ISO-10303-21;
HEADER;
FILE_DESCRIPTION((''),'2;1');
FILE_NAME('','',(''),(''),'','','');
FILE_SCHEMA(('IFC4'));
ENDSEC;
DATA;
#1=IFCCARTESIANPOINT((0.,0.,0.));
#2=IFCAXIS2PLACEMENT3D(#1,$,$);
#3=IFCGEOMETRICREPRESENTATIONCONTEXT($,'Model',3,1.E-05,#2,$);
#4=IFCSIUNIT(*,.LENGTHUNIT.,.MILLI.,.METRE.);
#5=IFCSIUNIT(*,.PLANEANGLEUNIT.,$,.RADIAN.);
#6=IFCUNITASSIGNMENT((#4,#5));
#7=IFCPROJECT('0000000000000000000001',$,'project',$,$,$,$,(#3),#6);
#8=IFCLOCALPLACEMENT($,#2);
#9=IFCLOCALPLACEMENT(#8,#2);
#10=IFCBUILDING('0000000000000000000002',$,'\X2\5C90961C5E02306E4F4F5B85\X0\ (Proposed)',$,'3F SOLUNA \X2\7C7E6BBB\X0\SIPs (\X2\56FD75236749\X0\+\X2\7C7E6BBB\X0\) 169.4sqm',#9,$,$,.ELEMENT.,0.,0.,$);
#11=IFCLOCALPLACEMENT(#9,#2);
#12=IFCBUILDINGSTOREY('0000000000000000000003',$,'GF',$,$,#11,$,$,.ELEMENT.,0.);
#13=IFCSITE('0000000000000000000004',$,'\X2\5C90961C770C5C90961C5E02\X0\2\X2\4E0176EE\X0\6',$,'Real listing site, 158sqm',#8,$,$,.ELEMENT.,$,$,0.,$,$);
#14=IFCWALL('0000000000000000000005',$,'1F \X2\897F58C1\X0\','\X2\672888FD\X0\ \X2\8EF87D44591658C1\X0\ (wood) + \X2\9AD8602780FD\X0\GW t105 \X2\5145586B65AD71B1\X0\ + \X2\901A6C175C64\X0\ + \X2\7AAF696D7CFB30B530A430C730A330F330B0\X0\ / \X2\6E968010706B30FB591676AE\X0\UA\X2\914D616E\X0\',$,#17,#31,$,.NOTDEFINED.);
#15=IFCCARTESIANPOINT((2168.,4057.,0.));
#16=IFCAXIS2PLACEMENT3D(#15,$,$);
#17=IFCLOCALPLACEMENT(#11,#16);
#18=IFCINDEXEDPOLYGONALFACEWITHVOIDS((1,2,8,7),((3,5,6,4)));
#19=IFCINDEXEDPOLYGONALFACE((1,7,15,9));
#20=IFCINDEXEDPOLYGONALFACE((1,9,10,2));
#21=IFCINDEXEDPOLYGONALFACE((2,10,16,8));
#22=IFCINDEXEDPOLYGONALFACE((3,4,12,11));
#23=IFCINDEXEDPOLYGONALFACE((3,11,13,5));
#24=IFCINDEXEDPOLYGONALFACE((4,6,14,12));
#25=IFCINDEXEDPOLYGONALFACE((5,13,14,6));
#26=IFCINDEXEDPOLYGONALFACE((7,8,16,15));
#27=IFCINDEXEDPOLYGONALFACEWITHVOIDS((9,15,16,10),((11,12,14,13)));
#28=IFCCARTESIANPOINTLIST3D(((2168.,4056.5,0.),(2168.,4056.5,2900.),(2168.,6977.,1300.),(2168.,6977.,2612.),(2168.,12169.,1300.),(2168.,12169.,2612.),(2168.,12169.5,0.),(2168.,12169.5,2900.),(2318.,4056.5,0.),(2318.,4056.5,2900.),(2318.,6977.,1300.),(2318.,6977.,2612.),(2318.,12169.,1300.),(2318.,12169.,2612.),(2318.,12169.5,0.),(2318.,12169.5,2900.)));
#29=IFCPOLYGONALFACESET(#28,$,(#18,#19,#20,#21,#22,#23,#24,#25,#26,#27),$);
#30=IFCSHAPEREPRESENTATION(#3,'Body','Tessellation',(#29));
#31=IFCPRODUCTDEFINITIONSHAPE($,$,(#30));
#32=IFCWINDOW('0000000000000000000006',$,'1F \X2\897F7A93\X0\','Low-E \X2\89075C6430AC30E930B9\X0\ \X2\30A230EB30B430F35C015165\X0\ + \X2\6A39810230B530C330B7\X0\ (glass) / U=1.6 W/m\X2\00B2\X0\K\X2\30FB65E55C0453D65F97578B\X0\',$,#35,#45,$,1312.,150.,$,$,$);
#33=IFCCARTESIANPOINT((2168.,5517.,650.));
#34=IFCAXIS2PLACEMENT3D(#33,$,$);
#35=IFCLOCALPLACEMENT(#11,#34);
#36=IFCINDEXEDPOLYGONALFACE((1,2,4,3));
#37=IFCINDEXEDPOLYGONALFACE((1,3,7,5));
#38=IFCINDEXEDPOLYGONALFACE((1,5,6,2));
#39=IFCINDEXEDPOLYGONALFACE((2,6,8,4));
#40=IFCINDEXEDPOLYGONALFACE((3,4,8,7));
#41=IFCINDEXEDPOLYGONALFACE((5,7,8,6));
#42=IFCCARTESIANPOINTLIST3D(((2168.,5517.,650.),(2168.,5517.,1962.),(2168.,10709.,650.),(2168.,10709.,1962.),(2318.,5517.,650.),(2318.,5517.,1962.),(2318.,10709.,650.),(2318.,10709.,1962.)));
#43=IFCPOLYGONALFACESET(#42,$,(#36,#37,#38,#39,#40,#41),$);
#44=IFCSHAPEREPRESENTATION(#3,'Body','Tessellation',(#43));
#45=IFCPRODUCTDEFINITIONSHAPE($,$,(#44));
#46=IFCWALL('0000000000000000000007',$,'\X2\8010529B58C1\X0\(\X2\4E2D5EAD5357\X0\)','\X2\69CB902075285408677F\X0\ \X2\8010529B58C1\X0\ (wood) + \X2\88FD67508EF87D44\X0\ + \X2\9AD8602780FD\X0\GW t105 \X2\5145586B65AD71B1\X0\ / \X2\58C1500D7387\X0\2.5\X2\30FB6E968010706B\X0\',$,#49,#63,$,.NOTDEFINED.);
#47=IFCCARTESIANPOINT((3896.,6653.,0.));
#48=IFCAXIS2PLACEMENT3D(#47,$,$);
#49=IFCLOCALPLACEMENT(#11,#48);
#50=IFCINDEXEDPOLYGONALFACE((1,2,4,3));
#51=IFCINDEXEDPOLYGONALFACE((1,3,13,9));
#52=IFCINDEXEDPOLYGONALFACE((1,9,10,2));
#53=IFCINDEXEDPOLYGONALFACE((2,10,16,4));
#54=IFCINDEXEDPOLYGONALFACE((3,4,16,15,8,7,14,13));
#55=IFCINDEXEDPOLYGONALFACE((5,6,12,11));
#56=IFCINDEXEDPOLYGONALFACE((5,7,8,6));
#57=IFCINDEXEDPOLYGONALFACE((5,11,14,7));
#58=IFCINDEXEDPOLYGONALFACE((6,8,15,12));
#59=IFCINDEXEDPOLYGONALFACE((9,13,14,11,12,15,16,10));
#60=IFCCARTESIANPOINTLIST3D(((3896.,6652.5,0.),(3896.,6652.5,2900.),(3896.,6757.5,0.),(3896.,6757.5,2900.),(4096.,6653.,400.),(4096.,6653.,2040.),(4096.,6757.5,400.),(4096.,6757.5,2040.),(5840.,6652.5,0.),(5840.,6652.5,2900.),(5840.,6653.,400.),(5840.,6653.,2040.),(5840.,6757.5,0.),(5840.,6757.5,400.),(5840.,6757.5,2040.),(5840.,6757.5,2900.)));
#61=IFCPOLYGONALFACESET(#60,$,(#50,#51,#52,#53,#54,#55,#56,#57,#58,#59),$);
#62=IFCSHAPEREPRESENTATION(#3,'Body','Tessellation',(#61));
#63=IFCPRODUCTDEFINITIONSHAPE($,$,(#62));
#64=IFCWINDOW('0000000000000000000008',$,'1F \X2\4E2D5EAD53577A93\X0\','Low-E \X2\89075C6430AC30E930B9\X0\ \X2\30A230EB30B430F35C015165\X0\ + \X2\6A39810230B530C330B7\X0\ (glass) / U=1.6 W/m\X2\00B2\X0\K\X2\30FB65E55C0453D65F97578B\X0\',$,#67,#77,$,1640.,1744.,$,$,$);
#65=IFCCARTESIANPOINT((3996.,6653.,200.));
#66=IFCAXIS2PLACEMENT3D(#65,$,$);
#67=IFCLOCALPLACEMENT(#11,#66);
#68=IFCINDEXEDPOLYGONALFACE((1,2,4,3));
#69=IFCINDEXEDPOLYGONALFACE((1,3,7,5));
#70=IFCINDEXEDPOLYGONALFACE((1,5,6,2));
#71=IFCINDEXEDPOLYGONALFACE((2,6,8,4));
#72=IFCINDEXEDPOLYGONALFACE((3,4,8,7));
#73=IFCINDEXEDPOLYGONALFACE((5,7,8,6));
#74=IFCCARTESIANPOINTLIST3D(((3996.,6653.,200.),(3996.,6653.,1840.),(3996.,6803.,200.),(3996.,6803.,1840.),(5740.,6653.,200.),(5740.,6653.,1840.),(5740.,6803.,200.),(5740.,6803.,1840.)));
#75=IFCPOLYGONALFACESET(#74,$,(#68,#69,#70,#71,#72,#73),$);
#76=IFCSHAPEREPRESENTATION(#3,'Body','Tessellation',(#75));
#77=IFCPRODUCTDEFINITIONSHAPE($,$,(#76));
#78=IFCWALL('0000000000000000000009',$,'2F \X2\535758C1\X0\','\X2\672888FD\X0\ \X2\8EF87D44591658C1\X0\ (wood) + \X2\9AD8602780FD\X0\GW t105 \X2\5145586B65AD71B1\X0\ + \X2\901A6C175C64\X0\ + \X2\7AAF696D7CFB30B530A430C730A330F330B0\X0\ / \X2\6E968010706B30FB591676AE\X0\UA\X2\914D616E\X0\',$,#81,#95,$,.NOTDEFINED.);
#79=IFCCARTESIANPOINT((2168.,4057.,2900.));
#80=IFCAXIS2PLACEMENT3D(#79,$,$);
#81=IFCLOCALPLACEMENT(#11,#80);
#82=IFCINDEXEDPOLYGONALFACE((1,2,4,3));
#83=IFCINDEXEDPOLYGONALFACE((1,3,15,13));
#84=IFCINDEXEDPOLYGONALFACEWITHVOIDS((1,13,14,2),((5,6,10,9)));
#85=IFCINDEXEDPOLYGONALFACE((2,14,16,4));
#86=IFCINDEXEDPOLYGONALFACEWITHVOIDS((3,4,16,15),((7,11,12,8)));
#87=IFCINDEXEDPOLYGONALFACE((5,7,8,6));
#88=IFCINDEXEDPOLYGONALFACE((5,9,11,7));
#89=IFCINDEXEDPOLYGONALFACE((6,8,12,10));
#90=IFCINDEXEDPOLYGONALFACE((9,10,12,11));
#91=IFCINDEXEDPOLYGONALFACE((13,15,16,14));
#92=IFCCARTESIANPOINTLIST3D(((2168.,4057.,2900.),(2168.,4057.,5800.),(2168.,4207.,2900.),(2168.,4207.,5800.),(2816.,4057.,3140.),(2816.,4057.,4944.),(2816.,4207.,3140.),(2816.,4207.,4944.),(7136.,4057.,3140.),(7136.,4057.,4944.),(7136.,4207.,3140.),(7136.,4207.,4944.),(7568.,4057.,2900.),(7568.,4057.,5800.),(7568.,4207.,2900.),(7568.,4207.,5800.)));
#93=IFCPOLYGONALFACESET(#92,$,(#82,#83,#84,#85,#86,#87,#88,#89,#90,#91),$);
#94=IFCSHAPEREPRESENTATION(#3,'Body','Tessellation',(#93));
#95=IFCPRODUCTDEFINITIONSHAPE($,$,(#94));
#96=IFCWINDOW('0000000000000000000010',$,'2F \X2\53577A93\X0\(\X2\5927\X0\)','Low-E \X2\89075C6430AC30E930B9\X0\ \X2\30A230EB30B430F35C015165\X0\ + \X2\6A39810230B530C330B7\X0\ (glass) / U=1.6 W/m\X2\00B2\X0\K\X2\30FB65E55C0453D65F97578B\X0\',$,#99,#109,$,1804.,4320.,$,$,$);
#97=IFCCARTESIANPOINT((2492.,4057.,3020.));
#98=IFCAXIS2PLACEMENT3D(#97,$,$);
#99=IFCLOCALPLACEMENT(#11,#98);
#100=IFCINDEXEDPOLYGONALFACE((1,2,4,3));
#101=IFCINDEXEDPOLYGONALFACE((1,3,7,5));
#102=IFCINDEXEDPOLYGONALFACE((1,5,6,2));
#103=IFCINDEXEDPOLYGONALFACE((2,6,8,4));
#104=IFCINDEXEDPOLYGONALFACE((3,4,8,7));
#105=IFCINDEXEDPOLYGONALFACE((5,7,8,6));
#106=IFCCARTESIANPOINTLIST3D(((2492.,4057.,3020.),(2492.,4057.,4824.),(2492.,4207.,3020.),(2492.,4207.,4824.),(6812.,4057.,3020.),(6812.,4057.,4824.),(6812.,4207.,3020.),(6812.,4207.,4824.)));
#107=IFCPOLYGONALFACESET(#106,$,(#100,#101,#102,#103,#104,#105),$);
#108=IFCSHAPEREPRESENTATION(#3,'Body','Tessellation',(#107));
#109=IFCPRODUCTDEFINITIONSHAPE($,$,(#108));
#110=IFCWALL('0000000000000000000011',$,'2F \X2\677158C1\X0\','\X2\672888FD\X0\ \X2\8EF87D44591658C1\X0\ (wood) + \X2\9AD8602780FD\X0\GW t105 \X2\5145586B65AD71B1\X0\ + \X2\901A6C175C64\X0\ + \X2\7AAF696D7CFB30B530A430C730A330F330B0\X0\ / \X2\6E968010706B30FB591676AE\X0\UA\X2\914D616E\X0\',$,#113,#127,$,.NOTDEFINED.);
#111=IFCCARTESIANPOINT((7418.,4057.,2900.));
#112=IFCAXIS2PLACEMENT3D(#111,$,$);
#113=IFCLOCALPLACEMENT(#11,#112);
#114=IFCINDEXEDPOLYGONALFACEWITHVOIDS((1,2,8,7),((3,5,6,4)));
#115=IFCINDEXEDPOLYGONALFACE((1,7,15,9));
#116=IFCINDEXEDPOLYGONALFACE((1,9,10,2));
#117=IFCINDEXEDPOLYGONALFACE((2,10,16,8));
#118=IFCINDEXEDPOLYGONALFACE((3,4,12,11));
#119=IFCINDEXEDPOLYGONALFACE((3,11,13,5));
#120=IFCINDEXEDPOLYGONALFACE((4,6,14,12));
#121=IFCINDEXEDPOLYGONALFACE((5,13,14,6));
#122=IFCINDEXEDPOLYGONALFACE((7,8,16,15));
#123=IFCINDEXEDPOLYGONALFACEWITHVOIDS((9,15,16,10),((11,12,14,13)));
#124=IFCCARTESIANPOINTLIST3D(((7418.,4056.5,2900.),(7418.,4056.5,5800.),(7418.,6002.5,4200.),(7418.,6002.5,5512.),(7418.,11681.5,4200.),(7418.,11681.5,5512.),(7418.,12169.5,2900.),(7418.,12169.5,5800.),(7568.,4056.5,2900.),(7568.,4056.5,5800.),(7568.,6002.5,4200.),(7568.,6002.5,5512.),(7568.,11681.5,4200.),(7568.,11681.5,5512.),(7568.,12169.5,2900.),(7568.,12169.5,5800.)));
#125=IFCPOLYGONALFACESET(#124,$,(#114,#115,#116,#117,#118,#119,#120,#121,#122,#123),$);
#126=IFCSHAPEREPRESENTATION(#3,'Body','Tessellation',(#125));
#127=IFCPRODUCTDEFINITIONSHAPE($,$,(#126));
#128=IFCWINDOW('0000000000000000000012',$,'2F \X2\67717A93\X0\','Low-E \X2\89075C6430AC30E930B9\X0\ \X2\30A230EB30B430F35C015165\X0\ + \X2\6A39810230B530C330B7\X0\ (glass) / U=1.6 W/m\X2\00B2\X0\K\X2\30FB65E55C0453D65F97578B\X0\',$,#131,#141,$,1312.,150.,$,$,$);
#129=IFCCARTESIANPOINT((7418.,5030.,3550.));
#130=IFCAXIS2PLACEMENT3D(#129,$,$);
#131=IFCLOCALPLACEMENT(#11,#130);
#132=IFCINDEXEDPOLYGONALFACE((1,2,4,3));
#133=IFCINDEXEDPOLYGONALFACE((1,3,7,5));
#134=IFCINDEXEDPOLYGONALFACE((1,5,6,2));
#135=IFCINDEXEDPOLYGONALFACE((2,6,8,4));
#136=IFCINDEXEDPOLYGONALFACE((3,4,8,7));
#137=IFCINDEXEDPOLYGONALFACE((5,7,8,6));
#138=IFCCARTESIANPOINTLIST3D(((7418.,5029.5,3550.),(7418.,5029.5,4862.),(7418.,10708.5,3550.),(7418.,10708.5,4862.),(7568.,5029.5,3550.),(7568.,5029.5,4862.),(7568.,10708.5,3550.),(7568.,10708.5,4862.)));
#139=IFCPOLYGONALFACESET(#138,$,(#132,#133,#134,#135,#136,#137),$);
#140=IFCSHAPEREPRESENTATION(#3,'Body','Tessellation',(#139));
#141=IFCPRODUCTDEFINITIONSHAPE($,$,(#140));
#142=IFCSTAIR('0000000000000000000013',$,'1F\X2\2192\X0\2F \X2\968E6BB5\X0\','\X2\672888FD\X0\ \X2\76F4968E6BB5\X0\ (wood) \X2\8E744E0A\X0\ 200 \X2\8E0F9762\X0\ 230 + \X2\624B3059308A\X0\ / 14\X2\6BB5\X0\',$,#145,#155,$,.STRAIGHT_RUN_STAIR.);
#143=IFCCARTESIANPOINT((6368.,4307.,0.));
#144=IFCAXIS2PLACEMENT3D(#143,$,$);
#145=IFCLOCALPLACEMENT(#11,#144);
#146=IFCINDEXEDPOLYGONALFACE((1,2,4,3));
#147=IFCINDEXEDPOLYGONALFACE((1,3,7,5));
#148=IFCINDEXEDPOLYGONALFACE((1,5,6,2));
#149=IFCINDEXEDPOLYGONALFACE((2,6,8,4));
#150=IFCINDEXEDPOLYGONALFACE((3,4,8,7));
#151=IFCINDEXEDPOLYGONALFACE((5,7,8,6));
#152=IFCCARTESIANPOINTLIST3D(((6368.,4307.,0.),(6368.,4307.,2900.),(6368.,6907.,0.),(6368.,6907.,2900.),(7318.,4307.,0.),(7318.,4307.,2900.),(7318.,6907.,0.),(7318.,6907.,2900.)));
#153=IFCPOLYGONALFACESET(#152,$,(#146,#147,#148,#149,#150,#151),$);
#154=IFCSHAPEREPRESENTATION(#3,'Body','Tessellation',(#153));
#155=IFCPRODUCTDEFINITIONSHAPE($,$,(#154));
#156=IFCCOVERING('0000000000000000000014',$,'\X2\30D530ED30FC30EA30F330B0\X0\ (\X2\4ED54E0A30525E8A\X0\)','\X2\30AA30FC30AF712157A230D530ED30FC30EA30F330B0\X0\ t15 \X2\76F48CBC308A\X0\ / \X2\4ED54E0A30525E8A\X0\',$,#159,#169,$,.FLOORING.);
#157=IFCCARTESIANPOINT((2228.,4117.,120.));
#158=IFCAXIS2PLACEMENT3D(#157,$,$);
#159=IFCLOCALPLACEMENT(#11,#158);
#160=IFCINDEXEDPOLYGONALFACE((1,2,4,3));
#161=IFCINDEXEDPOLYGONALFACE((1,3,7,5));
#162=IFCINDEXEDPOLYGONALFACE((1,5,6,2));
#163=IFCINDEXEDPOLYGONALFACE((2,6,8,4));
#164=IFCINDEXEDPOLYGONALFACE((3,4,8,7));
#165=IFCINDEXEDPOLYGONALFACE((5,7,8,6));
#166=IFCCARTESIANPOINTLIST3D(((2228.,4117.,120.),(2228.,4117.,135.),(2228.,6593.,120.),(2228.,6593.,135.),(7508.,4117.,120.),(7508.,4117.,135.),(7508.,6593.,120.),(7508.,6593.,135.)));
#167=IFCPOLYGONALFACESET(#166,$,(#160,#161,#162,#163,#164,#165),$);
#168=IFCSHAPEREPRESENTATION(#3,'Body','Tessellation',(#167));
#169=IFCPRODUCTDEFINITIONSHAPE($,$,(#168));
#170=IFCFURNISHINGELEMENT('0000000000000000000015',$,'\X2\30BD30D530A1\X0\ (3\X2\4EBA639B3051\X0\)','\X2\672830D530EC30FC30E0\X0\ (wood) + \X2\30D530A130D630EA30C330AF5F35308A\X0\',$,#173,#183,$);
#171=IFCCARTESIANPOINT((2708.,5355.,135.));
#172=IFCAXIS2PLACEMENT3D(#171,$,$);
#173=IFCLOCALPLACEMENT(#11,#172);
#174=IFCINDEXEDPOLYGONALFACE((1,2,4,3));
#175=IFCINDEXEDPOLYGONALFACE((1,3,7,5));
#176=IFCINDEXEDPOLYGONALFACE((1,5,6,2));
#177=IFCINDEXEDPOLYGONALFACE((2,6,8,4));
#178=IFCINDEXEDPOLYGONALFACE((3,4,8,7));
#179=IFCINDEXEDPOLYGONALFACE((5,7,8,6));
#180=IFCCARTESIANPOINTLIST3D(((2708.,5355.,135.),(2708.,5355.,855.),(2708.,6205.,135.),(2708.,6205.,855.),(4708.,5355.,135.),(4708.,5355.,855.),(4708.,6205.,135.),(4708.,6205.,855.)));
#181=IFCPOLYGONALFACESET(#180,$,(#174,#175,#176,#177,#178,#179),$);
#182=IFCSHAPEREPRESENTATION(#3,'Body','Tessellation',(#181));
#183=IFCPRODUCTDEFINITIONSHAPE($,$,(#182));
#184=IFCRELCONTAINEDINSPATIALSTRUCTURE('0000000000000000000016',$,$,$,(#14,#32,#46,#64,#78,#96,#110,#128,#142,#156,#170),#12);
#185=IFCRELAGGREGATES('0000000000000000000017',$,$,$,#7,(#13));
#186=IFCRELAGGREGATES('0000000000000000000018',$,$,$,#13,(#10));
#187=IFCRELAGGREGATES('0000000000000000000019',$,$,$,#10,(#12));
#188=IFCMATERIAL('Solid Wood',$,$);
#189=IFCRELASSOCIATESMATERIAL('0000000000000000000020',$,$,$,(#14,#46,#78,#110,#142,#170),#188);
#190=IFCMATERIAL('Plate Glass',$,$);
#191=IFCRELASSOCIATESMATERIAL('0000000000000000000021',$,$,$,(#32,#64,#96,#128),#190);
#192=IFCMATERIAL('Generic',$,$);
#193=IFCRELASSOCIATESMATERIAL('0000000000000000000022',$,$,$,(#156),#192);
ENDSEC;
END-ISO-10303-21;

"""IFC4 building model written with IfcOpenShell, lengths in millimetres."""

from ifc_helpers import new_model, si_unit, frame, frame_2d, origin, place, context, project, spatial, rectangle, extrude, material, element, fill, save


model = new_model("IFC4")

# Units and contexts
model_context = context("Model", 3, precision=1e-05, world=origin())
ifc_project = project(units=[si_unit("LENGTHUNIT", "METRE", prefix="MILLI"), si_unit("PLANEANGLEUNIT", "RADIAN")], contexts=[model_context])

# Site, building, storey
site_placement = place(None, origin())
site = spatial("IfcSite", under=ifc_project, at=site_placement, Name="岐阜県岐阜市2丁目6", ObjectType="Real listing site, 158sqm", CompositionType="ELEMENT", RefElevation=0.0)
building_placement = place(site_placement, origin())
building = spatial("IfcBuilding", under=site, at=building_placement, Name="岐阜市の住宅 (Proposed)", ObjectType="3F SOLUNA 籾殻SIPs (国産杉+籾殻) 169.4sqm", CompositionType="ELEMENT", ElevationOfRefHeight=0.0, ElevationOfTerrain=0.0)
storey_placement = place(building_placement, origin())
storey = spatial("IfcBuildingStorey", under=building, at=storey_placement, Name="GF", CompositionType="ELEMENT", Elevation=0.0)

# Shared definitions
ifc_material_1 = material(Name="Solid Wood")
ifc_material_2 = material(Name="Generic")

# Shared definitions
ifc_material_3 = material(Name="Plate Glass")

# Walls, openings, windows
wall_1_placement = place(storey_placement, frame((2168.0, 4057.0, 0.0)))
wall_1 = element("IfcWall", 1, at=wall_1_placement, inside=storey, material=ifc_material_1, Name="1F 西壁", Description="木製 軸組外壁 (wood) + 高性能GW t105 充填断熱 + 通気層 + 窯業系サイディング / 準耐火・外皮UA配慮", PredefinedType="NOTDEFINED", context=model_context, shape_type="SweptSolid", body=[
    extrude(rectangle(XDim=150.0, YDim=8113.0, at=frame_2d((75.0, 4056.0))), frame((2168.0, 4057.0, 0.0)), (0.0, 0.0, 1.0), 2900.0),
])
opening_1_placement = place(storey_placement, frame((2168.0, 5517.0, 650.0)))
opening_1 = element("IfcOpeningElement", 2, at=opening_1_placement, cuts=wall_1, PredefinedType="NOTDEFINED", context=model_context, shape_type="SweptSolid", body=[
    extrude(rectangle(XDim=150.0, YDim=5192.0, at=frame_2d((75.0, 2596.0))), frame((2168.0, 5517.0, 650.0)), (0.0, 0.0, 1.0), 1312.0),
])
window_1_placement = place(storey_placement, frame((2168.0, 5517.0, 650.0)))
window_1 = element("IfcWindow", 3, at=window_1_placement, inside=storey, material=ifc_material_3, Name="1F 西窓", Description="Low-E 複層ガラス アルゴン封入 + 樹脂サッシ (glass) / U=1.6 W/m²K・日射取得型", OverallHeight=1312.0, OverallWidth=150.0, context=model_context, shape_type="SweptSolid", body=[
    extrude(rectangle(XDim=150.0, YDim=5192.0, at=frame_2d((75.0, 2596.0))), frame((2168.0, 5517.0, 650.0)), (0.0, 0.0, 1.0), 1312.0),
])
fill(opening_1, window_1)
wall_2_placement = place(storey_placement, frame((3896.0, 6653.0, 0.0)))
wall_2 = element("IfcWall", 4, at=wall_2_placement, inside=storey, material=ifc_material_1, Name="耐力壁(中庭南)", Description="構造用合板 耐力壁 (wood) + 製材軸組 + 高性能GW t105 充填断熱 / 壁倍率2.5・準耐火", PredefinedType="NOTDEFINED", context=model_context, shape_type="SweptSolid", body=[
    extrude(rectangle(XDim=1944.0, YDim=105.0, at=frame_2d((972.0, 52.0))), frame((3896.0, 6653.0, 0.0)), (0.0, 0.0, 1.0), 2900.0),
])
opening_2_placement = place(storey_placement, frame((3996.0, 6653.0, 200.0)))
opening_2 = element("IfcOpeningElement", 5, at=opening_2_placement, cuts=wall_2, PredefinedType="NOTDEFINED", context=model_context, shape_type="SweptSolid", body=[
    extrude(rectangle(XDim=1744.0, YDim=150.0, at=frame_2d((872.0, 75.0))), frame((3996.0, 6653.0, 200.0)), (0.0, 0.0, 1.0), 1640.0),
])
window_2_placement = place(storey_placement, frame((3996.0, 6653.0, 200.0)))
window_2 = element("IfcWindow", 6, at=window_2_placement, inside=storey, material=ifc_material_3, Name="1F 中庭南窓", Description="Low-E 複層ガラス アルゴン封入 + 樹脂サッシ (glass) / U=1.6 W/m²K・日射取得型", OverallHeight=1640.0, OverallWidth=1744.0, context=model_context, shape_type="SweptSolid", body=[
    extrude(rectangle(XDim=1744.0, YDim=150.0, at=frame_2d((872.0, 75.0))), frame((3996.0, 6653.0, 200.0)), (0.0, 0.0, 1.0), 1640.0),
])
fill(opening_2, window_2)

# Walls, openings, windows
wall_3_placement = place(storey_placement, frame((2168.0, 4057.0, 2900.0)))
wall_3 = element("IfcWall", 7, at=wall_3_placement, inside=storey, material=ifc_material_1, Name="2F 南壁", Description="木製 軸組外壁 (wood) + 高性能GW t105 充填断熱 + 通気層 + 窯業系サイディング / 準耐火・外皮UA配慮", PredefinedType="NOTDEFINED", context=model_context, shape_type="SweptSolid", body=[
    extrude(rectangle(XDim=5400.0, YDim=150.0, at=frame_2d((2700.0, 75.0))), frame((2168.0, 4057.0, 2900.0)), (0.0, 0.0, 1.0), 2900.0),
])
opening_3_placement = place(storey_placement, frame((2492.0, 4057.0, 3020.0)))
opening_3 = element("IfcOpeningElement", 8, at=opening_3_placement, cuts=wall_3, PredefinedType="NOTDEFINED", context=model_context, shape_type="SweptSolid", body=[
    extrude(rectangle(XDim=4320.0, YDim=150.0, at=frame_2d((2160.0, 75.0))), frame((2492.0, 4057.0, 3020.0)), (0.0, 0.0, 1.0), 1804.0),
])
window_3_placement = place(storey_placement, frame((2492.0, 4057.0, 3020.0)))
window_3 = element("IfcWindow", 9, at=window_3_placement, inside=storey, material=ifc_material_3, Name="2F 南窓(大)", Description="Low-E 複層ガラス アルゴン封入 + 樹脂サッシ (glass) / U=1.6 W/m²K・日射取得型", OverallHeight=1804.0, OverallWidth=4320.0, context=model_context, shape_type="SweptSolid", body=[
    extrude(rectangle(XDim=4320.0, YDim=150.0, at=frame_2d((2160.0, 75.0))), frame((2492.0, 4057.0, 3020.0)), (0.0, 0.0, 1.0), 1804.0),
])
fill(opening_3, window_3)
wall_4_placement = place(storey_placement, frame((7418.0, 4057.0, 2900.0)))
wall_4 = element("IfcWall", 10, at=wall_4_placement, inside=storey, material=ifc_material_1, Name="2F 東壁", Description="木製 軸組外壁 (wood) + 高性能GW t105 充填断熱 + 通気層 + 窯業系サイディング / 準耐火・外皮UA配慮", PredefinedType="NOTDEFINED", context=model_context, shape_type="SweptSolid", body=[
    extrude(rectangle(XDim=150.0, YDim=8113.0, at=frame_2d((75.0, 4056.0))), frame((7418.0, 4057.0, 2900.0)), (0.0, 0.0, 1.0), 2900.0),
])
opening_4_placement = place(storey_placement, frame((7418.0, 5030.0, 3550.0)))
opening_4 = element("IfcOpeningElement", 11, at=opening_4_placement, cuts=wall_4, PredefinedType="NOTDEFINED", context=model_context, shape_type="SweptSolid", body=[
    extrude(rectangle(XDim=150.0, YDim=5679.0, at=frame_2d((75.0, 2839.0))), frame((7418.0, 5030.0, 3550.0)), (0.0, 0.0, 1.0), 1312.0),
])
window_4_placement = place(storey_placement, frame((7418.0, 5030.0, 3550.0)))
window_4 = element("IfcWindow", 12, at=window_4_placement, inside=storey, material=ifc_material_3, Name="2F 東窓", Description="Low-E 複層ガラス アルゴン封入 + 樹脂サッシ (glass) / U=1.6 W/m²K・日射取得型", OverallHeight=1312.0, OverallWidth=150.0, context=model_context, shape_type="SweptSolid", body=[
    extrude(rectangle(XDim=150.0, YDim=5679.0, at=frame_2d((75.0, 2839.0))), frame((7418.0, 5030.0, 3550.0)), (0.0, 0.0, 1.0), 1312.0),
])
fill(opening_4, window_4)

# Stair
stair_placement = place(storey_placement, frame((6368.0, 4307.0, 0.0)))
element("IfcStair", 13, at=stair_placement, inside=storey, material=ifc_material_1, Name="1F→2F 階段", Description="木製 直階段 (wood) 蹴上 200 踏面 230 + 手すり / 14段", PredefinedType="STRAIGHT_RUN_STAIR", context=model_context, shape_type="SweptSolid", body=[
    extrude(rectangle(XDim=950.0, YDim=2600.0, at=frame_2d((475.0, 1300.0))), frame((6368.0, 4307.0, 0.0)), (0.0, 0.0, 1.0), 2900.0),
])

# Covering
covering_placement = place(storey_placement, frame((2228.0, 4117.0, 120.0)))
element("IfcCovering", 14, at=covering_placement, inside=storey, material=ifc_material_2, Name="フローリング (仕上げ床)", Description="オーク無垢フローリング t15 直貼り / 仕上げ床", PredefinedType="FLOORING", context=model_context, shape_type="SweptSolid", body=[
    extrude(rectangle(XDim=5280.0, YDim=2476.0, at=frame_2d((2640.0, 1238.0))), frame((2228.0, 4117.0, 120.0)), (0.0, 0.0, 1.0), 15.0),
])

# Furnishing element
furnishing_1_placement = place(storey_placement, frame((2708.0, 5355.0, 135.0)))
element("IfcFurnishingElement", 15, at=furnishing_1_placement, inside=storey, material=ifc_material_1, Name="ソファ (3人掛け)", Description="木フレーム (wood) + ファブリック張り", context=model_context, shape_type="SweptSolid", body=[
    extrude(rectangle(XDim=2000.0, YDim=850.0, at=frame_2d((1000.0, 425.0))), frame((2708.0, 5355.0, 135.0)), (0.0, 0.0, 1.0), 720.0),
])

save(model, "model.ifc")
